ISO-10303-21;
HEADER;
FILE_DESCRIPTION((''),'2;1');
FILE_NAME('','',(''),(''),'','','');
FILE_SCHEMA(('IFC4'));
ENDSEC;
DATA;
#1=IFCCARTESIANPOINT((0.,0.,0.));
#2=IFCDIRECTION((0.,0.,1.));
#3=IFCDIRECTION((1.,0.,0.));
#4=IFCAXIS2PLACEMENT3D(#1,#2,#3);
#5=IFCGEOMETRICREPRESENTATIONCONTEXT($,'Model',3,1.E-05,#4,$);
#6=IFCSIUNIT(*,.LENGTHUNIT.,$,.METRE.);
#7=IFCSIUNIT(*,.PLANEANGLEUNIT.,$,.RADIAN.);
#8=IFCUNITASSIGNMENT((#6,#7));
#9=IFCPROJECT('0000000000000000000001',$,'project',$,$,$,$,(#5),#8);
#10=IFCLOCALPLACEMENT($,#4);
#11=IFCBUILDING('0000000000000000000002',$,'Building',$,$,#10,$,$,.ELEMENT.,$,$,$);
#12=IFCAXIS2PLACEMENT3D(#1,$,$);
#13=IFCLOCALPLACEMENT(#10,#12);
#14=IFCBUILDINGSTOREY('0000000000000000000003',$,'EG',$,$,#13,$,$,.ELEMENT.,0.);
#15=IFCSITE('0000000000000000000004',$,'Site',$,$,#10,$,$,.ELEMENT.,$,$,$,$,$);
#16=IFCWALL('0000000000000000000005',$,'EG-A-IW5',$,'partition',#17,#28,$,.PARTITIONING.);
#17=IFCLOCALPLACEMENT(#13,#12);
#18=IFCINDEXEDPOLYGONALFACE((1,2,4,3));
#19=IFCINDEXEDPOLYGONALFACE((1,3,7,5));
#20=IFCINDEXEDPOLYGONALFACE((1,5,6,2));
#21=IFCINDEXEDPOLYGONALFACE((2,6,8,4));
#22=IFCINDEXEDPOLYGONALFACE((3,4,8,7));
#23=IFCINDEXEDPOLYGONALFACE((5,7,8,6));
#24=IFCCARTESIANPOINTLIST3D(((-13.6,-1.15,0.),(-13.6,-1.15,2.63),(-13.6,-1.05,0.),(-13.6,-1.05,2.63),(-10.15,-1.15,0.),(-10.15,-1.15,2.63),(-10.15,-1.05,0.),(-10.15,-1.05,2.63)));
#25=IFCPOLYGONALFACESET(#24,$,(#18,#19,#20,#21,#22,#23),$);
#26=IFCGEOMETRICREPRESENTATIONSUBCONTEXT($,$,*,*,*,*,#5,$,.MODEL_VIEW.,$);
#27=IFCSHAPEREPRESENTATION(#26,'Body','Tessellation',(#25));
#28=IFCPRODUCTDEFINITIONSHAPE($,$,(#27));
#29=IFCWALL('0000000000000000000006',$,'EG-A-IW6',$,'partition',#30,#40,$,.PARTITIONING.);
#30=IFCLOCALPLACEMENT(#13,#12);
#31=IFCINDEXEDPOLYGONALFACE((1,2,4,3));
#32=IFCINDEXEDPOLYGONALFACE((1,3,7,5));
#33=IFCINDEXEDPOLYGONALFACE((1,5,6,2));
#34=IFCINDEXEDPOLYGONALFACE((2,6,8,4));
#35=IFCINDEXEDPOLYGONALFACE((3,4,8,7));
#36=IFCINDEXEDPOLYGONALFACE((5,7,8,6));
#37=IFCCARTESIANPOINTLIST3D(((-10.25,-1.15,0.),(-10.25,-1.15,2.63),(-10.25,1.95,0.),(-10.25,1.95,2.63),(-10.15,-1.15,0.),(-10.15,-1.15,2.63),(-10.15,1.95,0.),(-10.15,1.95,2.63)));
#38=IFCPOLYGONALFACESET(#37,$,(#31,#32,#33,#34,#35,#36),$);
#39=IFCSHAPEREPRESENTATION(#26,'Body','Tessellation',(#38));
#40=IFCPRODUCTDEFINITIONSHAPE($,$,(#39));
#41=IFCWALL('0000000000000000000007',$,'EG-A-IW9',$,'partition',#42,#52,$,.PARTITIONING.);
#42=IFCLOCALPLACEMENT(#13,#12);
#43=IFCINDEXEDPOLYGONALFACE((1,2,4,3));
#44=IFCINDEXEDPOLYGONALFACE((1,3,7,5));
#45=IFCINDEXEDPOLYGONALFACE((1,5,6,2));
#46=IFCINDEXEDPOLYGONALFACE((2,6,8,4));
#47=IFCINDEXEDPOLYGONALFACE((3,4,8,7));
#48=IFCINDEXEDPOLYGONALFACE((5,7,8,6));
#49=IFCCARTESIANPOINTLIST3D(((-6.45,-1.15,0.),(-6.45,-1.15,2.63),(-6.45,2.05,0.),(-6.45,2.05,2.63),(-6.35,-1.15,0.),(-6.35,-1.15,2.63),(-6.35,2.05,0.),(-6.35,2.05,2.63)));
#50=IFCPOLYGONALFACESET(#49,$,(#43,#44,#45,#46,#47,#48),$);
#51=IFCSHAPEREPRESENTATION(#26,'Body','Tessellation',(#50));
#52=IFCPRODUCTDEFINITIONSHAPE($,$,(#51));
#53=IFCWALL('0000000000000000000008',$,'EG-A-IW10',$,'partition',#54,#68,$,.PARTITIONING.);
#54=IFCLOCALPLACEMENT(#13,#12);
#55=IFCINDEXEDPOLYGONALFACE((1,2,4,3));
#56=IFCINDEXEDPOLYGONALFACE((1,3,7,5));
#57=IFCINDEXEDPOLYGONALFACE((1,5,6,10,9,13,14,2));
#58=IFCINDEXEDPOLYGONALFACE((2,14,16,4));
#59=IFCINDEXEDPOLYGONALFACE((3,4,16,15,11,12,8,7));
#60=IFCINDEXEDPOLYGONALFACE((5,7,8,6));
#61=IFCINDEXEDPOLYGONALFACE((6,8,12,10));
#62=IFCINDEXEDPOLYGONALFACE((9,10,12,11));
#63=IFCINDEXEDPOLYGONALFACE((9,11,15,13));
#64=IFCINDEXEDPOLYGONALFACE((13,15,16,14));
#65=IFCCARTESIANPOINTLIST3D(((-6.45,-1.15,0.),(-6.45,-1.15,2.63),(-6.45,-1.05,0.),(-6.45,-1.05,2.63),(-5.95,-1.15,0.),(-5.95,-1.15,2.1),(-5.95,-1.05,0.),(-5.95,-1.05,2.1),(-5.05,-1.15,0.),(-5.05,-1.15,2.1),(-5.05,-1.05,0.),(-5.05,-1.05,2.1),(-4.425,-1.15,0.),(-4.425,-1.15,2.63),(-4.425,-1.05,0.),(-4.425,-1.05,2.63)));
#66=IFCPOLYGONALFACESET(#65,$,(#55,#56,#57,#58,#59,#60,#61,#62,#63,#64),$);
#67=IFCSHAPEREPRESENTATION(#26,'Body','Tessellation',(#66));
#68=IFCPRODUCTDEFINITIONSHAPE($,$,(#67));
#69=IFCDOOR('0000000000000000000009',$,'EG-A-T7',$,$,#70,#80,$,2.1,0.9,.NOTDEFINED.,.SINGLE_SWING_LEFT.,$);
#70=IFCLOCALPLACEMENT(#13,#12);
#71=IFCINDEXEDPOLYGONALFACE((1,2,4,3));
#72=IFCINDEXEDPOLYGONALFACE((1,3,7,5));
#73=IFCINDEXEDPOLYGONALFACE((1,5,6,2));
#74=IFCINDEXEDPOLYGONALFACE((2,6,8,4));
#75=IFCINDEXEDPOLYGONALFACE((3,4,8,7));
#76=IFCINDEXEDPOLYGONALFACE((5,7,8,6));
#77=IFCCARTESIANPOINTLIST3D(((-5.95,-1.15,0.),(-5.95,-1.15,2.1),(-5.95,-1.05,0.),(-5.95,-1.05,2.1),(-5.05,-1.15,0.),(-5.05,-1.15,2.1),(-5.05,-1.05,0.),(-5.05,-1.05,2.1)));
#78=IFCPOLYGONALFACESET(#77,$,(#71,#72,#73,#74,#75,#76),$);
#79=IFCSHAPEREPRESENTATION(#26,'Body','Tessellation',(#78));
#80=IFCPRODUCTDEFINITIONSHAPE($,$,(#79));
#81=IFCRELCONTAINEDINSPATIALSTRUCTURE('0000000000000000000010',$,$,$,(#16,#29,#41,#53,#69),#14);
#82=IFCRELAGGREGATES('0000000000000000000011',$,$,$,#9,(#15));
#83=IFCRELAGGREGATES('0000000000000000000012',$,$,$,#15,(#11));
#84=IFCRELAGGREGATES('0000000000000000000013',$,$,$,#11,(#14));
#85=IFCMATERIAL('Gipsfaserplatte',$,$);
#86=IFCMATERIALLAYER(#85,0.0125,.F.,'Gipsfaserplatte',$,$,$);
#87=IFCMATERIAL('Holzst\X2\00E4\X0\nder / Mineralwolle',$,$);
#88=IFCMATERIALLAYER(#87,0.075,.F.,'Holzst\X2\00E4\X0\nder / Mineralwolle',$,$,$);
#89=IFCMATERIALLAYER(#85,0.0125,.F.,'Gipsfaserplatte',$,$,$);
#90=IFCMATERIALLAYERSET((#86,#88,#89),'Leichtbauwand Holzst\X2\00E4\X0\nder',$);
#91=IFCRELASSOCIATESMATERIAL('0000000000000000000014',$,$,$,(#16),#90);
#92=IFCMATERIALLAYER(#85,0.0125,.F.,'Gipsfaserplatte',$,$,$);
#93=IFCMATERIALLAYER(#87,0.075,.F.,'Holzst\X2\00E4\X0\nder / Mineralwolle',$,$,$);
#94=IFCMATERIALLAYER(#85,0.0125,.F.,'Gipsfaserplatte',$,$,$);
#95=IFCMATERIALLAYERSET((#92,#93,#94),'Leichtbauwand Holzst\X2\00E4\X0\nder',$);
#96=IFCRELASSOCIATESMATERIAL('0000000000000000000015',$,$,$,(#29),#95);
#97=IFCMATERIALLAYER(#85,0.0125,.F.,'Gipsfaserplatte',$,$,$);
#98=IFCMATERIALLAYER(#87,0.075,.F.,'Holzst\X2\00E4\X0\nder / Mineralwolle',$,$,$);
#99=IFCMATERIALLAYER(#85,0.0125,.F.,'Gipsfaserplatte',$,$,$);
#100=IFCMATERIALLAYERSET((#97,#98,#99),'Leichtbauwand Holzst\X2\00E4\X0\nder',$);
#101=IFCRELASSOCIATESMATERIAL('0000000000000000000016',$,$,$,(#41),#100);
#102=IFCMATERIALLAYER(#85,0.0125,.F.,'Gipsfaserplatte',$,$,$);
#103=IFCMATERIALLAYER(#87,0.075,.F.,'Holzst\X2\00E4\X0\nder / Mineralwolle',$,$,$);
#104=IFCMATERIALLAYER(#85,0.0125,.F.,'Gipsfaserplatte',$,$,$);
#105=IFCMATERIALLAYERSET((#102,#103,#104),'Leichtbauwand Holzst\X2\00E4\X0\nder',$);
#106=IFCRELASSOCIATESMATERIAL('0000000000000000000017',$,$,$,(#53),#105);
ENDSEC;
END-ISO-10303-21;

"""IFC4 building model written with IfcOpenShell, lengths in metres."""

from ifc_helpers import new_model, si_unit, frame, frame_2d, origin, origin_with_axes, place, context, subcontext, project, spatial, rectangle, extrude, material, layer, layer_set, element, fill, save


model = new_model("IFC4")

# Units and contexts
model_context = context("Model", 3, precision=1e-05, world=origin_with_axes())
sub_context = subcontext(model_context, None, None, "MODEL_VIEW")
ifc_project = project(units=[si_unit("LENGTHUNIT", "METRE"), si_unit("PLANEANGLEUNIT", "RADIAN")], contexts=[model_context])

# Site, building, storey
placement = place(None, origin_with_axes())
site = spatial("IfcSite", under=ifc_project, at=placement, Name="Site", CompositionType="ELEMENT")
building = spatial("IfcBuilding", under=site, at=placement, Name="Building", CompositionType="ELEMENT")
storey_placement = place(placement, origin())
storey = spatial("IfcBuildingStorey", under=building, at=storey_placement, Name="EG", CompositionType="ELEMENT", Elevation=0.0)

# Shared definitions
ifc_material_1 = material(Name="Gipsfaserplatte")

# Walls
ifc_layer_1 = layer(ifc_material_1, 0.0125, ventilated=False, Name="Gipsfaserplatte")
ifc_material_2 = material(Name="Holzständer / Mineralwolle")
ifc_layer_2 = layer(ifc_material_2, 0.075, ventilated=False, Name="Holzständer / Mineralwolle")
ifc_layer_3 = layer(ifc_material_1, 0.0125, ventilated=False, Name="Gipsfaserplatte")
ifc_layer_set_1 = layer_set([ifc_layer_1, ifc_layer_2, ifc_layer_3], Name="Leichtbauwand Holzständer")
wall_1_placement = place(storey_placement, frame((-13.6, -1.1, 0.0), z_axis=(0.0, 0.0, 1.0), x_axis=(1.0, 0.0, 0.0)))
element("IfcWall", 1, at=wall_1_placement, inside=storey, material=ifc_layer_set_1, Name="EG-A-IW5", ObjectType="partition", PredefinedType="PARTITIONING", context=sub_context, shape_type="SweptSolid", body=[
    extrude(rectangle(XDim=3.45, YDim=0.1, at=frame_2d((1.725, 0.0))), origin(), (0.0, 0.0, 1.0), 2.63),
])
ifc_layer_4 = layer(ifc_material_1, 0.0125, ventilated=False, Name="Gipsfaserplatte")
ifc_layer_5 = layer(ifc_material_2, 0.075, ventilated=False, Name="Holzständer / Mineralwolle")
ifc_layer_6 = layer(ifc_material_1, 0.0125, ventilated=False, Name="Gipsfaserplatte")
ifc_layer_set_2 = layer_set([ifc_layer_4, ifc_layer_5, ifc_layer_6], Name="Leichtbauwand Holzständer")
wall_2_placement = place(storey_placement, frame((-10.2, -1.15, 0.0), z_axis=(0.0, 0.0, 1.0), x_axis=(0.0, 1.0, 0.0)))
element("IfcWall", 2, at=wall_2_placement, inside=storey, material=ifc_layer_set_2, Name="EG-A-IW6", ObjectType="partition", PredefinedType="PARTITIONING", context=sub_context, shape_type="SweptSolid", body=[
    extrude(rectangle(XDim=3.1, YDim=0.1, at=frame_2d((1.55, 0.0))), origin(), (0.0, 0.0, 1.0), 2.63),
])
ifc_layer_7 = layer(ifc_material_1, 0.0125, ventilated=False, Name="Gipsfaserplatte")
ifc_layer_8 = layer(ifc_material_2, 0.075, ventilated=False, Name="Holzständer / Mineralwolle")
ifc_layer_9 = layer(ifc_material_1, 0.0125, ventilated=False, Name="Gipsfaserplatte")
ifc_layer_set_3 = layer_set([ifc_layer_7, ifc_layer_8, ifc_layer_9], Name="Leichtbauwand Holzständer")
wall_3_placement = place(storey_placement, frame((-6.4, -1.15, 0.0), z_axis=(0.0, 0.0, 1.0), x_axis=(0.0, 1.0, 0.0)))
element("IfcWall", 3, at=wall_3_placement, inside=storey, material=ifc_layer_set_3, Name="EG-A-IW9", ObjectType="partition", PredefinedType="PARTITIONING", context=sub_context, shape_type="SweptSolid", body=[
    extrude(rectangle(XDim=3.2, YDim=0.1, at=frame_2d((1.6, 0.0))), origin(), (0.0, 0.0, 1.0), 2.63),
])

# Wall, opening, door
ifc_layer_10 = layer(ifc_material_1, 0.0125, ventilated=False, Name="Gipsfaserplatte")
ifc_layer_11 = layer(ifc_material_2, 0.075, ventilated=False, Name="Holzständer / Mineralwolle")
ifc_layer_12 = layer(ifc_material_1, 0.0125, ventilated=False, Name="Gipsfaserplatte")
ifc_layer_set_4 = layer_set([ifc_layer_10, ifc_layer_11, ifc_layer_12], Name="Leichtbauwand Holzständer")
wall_4_placement = place(storey_placement, frame((-6.45, -1.1, 0.0), z_axis=(0.0, 0.0, 1.0), x_axis=(1.0, 0.0, 0.0)))
wall_4 = element("IfcWall", 4, at=wall_4_placement, inside=storey, material=ifc_layer_set_4, Name="EG-A-IW10", ObjectType="partition", PredefinedType="PARTITIONING", context=sub_context, shape_type="SweptSolid", body=[
    extrude(rectangle(XDim=2.025, YDim=0.1, at=frame_2d((1.0125, 0.0))), origin(), (0.0, 0.0, 1.0), 2.63),
])
opening_1_placement = place(wall_4_placement, frame((0.95, 0.1, 0.0), z_axis=(0.0, -1.0, 0.0), x_axis=(1.0, 0.0, 0.0)))
opening_1 = element("IfcOpeningElement", 5, at=opening_1_placement, cuts=wall_4, PredefinedType="OPENING", context=sub_context, shape_type="SweptSolid", body=[
    extrude(rectangle(XDim=0.9, YDim=2.1, at=frame_2d((0.0, 1.05))), origin(), (0.0, 0.0, 1.0), 0.2),
])
door_1_placement = place(wall_4_placement, frame((0.95, 0.05, 0.0), z_axis=(0.0, -1.0, 0.0), x_axis=(1.0, 0.0, 0.0)))
door_1 = element("IfcDoor", 6, at=door_1_placement, inside=storey, Name="EG-A-T7", OperationType="SINGLE_SWING_LEFT", OverallHeight=2.1, OverallWidth=0.9, PredefinedType="NOTDEFINED", context=sub_context, shape_type="SweptSolid", body=[
    extrude(rectangle(XDim=0.9, YDim=2.1, at=frame_2d((0.0, 1.05))), origin(), (0.0, 0.0, 1.0), 0.1),
])
fill(opening_1, door_1)

save(model, "model.ifc")
